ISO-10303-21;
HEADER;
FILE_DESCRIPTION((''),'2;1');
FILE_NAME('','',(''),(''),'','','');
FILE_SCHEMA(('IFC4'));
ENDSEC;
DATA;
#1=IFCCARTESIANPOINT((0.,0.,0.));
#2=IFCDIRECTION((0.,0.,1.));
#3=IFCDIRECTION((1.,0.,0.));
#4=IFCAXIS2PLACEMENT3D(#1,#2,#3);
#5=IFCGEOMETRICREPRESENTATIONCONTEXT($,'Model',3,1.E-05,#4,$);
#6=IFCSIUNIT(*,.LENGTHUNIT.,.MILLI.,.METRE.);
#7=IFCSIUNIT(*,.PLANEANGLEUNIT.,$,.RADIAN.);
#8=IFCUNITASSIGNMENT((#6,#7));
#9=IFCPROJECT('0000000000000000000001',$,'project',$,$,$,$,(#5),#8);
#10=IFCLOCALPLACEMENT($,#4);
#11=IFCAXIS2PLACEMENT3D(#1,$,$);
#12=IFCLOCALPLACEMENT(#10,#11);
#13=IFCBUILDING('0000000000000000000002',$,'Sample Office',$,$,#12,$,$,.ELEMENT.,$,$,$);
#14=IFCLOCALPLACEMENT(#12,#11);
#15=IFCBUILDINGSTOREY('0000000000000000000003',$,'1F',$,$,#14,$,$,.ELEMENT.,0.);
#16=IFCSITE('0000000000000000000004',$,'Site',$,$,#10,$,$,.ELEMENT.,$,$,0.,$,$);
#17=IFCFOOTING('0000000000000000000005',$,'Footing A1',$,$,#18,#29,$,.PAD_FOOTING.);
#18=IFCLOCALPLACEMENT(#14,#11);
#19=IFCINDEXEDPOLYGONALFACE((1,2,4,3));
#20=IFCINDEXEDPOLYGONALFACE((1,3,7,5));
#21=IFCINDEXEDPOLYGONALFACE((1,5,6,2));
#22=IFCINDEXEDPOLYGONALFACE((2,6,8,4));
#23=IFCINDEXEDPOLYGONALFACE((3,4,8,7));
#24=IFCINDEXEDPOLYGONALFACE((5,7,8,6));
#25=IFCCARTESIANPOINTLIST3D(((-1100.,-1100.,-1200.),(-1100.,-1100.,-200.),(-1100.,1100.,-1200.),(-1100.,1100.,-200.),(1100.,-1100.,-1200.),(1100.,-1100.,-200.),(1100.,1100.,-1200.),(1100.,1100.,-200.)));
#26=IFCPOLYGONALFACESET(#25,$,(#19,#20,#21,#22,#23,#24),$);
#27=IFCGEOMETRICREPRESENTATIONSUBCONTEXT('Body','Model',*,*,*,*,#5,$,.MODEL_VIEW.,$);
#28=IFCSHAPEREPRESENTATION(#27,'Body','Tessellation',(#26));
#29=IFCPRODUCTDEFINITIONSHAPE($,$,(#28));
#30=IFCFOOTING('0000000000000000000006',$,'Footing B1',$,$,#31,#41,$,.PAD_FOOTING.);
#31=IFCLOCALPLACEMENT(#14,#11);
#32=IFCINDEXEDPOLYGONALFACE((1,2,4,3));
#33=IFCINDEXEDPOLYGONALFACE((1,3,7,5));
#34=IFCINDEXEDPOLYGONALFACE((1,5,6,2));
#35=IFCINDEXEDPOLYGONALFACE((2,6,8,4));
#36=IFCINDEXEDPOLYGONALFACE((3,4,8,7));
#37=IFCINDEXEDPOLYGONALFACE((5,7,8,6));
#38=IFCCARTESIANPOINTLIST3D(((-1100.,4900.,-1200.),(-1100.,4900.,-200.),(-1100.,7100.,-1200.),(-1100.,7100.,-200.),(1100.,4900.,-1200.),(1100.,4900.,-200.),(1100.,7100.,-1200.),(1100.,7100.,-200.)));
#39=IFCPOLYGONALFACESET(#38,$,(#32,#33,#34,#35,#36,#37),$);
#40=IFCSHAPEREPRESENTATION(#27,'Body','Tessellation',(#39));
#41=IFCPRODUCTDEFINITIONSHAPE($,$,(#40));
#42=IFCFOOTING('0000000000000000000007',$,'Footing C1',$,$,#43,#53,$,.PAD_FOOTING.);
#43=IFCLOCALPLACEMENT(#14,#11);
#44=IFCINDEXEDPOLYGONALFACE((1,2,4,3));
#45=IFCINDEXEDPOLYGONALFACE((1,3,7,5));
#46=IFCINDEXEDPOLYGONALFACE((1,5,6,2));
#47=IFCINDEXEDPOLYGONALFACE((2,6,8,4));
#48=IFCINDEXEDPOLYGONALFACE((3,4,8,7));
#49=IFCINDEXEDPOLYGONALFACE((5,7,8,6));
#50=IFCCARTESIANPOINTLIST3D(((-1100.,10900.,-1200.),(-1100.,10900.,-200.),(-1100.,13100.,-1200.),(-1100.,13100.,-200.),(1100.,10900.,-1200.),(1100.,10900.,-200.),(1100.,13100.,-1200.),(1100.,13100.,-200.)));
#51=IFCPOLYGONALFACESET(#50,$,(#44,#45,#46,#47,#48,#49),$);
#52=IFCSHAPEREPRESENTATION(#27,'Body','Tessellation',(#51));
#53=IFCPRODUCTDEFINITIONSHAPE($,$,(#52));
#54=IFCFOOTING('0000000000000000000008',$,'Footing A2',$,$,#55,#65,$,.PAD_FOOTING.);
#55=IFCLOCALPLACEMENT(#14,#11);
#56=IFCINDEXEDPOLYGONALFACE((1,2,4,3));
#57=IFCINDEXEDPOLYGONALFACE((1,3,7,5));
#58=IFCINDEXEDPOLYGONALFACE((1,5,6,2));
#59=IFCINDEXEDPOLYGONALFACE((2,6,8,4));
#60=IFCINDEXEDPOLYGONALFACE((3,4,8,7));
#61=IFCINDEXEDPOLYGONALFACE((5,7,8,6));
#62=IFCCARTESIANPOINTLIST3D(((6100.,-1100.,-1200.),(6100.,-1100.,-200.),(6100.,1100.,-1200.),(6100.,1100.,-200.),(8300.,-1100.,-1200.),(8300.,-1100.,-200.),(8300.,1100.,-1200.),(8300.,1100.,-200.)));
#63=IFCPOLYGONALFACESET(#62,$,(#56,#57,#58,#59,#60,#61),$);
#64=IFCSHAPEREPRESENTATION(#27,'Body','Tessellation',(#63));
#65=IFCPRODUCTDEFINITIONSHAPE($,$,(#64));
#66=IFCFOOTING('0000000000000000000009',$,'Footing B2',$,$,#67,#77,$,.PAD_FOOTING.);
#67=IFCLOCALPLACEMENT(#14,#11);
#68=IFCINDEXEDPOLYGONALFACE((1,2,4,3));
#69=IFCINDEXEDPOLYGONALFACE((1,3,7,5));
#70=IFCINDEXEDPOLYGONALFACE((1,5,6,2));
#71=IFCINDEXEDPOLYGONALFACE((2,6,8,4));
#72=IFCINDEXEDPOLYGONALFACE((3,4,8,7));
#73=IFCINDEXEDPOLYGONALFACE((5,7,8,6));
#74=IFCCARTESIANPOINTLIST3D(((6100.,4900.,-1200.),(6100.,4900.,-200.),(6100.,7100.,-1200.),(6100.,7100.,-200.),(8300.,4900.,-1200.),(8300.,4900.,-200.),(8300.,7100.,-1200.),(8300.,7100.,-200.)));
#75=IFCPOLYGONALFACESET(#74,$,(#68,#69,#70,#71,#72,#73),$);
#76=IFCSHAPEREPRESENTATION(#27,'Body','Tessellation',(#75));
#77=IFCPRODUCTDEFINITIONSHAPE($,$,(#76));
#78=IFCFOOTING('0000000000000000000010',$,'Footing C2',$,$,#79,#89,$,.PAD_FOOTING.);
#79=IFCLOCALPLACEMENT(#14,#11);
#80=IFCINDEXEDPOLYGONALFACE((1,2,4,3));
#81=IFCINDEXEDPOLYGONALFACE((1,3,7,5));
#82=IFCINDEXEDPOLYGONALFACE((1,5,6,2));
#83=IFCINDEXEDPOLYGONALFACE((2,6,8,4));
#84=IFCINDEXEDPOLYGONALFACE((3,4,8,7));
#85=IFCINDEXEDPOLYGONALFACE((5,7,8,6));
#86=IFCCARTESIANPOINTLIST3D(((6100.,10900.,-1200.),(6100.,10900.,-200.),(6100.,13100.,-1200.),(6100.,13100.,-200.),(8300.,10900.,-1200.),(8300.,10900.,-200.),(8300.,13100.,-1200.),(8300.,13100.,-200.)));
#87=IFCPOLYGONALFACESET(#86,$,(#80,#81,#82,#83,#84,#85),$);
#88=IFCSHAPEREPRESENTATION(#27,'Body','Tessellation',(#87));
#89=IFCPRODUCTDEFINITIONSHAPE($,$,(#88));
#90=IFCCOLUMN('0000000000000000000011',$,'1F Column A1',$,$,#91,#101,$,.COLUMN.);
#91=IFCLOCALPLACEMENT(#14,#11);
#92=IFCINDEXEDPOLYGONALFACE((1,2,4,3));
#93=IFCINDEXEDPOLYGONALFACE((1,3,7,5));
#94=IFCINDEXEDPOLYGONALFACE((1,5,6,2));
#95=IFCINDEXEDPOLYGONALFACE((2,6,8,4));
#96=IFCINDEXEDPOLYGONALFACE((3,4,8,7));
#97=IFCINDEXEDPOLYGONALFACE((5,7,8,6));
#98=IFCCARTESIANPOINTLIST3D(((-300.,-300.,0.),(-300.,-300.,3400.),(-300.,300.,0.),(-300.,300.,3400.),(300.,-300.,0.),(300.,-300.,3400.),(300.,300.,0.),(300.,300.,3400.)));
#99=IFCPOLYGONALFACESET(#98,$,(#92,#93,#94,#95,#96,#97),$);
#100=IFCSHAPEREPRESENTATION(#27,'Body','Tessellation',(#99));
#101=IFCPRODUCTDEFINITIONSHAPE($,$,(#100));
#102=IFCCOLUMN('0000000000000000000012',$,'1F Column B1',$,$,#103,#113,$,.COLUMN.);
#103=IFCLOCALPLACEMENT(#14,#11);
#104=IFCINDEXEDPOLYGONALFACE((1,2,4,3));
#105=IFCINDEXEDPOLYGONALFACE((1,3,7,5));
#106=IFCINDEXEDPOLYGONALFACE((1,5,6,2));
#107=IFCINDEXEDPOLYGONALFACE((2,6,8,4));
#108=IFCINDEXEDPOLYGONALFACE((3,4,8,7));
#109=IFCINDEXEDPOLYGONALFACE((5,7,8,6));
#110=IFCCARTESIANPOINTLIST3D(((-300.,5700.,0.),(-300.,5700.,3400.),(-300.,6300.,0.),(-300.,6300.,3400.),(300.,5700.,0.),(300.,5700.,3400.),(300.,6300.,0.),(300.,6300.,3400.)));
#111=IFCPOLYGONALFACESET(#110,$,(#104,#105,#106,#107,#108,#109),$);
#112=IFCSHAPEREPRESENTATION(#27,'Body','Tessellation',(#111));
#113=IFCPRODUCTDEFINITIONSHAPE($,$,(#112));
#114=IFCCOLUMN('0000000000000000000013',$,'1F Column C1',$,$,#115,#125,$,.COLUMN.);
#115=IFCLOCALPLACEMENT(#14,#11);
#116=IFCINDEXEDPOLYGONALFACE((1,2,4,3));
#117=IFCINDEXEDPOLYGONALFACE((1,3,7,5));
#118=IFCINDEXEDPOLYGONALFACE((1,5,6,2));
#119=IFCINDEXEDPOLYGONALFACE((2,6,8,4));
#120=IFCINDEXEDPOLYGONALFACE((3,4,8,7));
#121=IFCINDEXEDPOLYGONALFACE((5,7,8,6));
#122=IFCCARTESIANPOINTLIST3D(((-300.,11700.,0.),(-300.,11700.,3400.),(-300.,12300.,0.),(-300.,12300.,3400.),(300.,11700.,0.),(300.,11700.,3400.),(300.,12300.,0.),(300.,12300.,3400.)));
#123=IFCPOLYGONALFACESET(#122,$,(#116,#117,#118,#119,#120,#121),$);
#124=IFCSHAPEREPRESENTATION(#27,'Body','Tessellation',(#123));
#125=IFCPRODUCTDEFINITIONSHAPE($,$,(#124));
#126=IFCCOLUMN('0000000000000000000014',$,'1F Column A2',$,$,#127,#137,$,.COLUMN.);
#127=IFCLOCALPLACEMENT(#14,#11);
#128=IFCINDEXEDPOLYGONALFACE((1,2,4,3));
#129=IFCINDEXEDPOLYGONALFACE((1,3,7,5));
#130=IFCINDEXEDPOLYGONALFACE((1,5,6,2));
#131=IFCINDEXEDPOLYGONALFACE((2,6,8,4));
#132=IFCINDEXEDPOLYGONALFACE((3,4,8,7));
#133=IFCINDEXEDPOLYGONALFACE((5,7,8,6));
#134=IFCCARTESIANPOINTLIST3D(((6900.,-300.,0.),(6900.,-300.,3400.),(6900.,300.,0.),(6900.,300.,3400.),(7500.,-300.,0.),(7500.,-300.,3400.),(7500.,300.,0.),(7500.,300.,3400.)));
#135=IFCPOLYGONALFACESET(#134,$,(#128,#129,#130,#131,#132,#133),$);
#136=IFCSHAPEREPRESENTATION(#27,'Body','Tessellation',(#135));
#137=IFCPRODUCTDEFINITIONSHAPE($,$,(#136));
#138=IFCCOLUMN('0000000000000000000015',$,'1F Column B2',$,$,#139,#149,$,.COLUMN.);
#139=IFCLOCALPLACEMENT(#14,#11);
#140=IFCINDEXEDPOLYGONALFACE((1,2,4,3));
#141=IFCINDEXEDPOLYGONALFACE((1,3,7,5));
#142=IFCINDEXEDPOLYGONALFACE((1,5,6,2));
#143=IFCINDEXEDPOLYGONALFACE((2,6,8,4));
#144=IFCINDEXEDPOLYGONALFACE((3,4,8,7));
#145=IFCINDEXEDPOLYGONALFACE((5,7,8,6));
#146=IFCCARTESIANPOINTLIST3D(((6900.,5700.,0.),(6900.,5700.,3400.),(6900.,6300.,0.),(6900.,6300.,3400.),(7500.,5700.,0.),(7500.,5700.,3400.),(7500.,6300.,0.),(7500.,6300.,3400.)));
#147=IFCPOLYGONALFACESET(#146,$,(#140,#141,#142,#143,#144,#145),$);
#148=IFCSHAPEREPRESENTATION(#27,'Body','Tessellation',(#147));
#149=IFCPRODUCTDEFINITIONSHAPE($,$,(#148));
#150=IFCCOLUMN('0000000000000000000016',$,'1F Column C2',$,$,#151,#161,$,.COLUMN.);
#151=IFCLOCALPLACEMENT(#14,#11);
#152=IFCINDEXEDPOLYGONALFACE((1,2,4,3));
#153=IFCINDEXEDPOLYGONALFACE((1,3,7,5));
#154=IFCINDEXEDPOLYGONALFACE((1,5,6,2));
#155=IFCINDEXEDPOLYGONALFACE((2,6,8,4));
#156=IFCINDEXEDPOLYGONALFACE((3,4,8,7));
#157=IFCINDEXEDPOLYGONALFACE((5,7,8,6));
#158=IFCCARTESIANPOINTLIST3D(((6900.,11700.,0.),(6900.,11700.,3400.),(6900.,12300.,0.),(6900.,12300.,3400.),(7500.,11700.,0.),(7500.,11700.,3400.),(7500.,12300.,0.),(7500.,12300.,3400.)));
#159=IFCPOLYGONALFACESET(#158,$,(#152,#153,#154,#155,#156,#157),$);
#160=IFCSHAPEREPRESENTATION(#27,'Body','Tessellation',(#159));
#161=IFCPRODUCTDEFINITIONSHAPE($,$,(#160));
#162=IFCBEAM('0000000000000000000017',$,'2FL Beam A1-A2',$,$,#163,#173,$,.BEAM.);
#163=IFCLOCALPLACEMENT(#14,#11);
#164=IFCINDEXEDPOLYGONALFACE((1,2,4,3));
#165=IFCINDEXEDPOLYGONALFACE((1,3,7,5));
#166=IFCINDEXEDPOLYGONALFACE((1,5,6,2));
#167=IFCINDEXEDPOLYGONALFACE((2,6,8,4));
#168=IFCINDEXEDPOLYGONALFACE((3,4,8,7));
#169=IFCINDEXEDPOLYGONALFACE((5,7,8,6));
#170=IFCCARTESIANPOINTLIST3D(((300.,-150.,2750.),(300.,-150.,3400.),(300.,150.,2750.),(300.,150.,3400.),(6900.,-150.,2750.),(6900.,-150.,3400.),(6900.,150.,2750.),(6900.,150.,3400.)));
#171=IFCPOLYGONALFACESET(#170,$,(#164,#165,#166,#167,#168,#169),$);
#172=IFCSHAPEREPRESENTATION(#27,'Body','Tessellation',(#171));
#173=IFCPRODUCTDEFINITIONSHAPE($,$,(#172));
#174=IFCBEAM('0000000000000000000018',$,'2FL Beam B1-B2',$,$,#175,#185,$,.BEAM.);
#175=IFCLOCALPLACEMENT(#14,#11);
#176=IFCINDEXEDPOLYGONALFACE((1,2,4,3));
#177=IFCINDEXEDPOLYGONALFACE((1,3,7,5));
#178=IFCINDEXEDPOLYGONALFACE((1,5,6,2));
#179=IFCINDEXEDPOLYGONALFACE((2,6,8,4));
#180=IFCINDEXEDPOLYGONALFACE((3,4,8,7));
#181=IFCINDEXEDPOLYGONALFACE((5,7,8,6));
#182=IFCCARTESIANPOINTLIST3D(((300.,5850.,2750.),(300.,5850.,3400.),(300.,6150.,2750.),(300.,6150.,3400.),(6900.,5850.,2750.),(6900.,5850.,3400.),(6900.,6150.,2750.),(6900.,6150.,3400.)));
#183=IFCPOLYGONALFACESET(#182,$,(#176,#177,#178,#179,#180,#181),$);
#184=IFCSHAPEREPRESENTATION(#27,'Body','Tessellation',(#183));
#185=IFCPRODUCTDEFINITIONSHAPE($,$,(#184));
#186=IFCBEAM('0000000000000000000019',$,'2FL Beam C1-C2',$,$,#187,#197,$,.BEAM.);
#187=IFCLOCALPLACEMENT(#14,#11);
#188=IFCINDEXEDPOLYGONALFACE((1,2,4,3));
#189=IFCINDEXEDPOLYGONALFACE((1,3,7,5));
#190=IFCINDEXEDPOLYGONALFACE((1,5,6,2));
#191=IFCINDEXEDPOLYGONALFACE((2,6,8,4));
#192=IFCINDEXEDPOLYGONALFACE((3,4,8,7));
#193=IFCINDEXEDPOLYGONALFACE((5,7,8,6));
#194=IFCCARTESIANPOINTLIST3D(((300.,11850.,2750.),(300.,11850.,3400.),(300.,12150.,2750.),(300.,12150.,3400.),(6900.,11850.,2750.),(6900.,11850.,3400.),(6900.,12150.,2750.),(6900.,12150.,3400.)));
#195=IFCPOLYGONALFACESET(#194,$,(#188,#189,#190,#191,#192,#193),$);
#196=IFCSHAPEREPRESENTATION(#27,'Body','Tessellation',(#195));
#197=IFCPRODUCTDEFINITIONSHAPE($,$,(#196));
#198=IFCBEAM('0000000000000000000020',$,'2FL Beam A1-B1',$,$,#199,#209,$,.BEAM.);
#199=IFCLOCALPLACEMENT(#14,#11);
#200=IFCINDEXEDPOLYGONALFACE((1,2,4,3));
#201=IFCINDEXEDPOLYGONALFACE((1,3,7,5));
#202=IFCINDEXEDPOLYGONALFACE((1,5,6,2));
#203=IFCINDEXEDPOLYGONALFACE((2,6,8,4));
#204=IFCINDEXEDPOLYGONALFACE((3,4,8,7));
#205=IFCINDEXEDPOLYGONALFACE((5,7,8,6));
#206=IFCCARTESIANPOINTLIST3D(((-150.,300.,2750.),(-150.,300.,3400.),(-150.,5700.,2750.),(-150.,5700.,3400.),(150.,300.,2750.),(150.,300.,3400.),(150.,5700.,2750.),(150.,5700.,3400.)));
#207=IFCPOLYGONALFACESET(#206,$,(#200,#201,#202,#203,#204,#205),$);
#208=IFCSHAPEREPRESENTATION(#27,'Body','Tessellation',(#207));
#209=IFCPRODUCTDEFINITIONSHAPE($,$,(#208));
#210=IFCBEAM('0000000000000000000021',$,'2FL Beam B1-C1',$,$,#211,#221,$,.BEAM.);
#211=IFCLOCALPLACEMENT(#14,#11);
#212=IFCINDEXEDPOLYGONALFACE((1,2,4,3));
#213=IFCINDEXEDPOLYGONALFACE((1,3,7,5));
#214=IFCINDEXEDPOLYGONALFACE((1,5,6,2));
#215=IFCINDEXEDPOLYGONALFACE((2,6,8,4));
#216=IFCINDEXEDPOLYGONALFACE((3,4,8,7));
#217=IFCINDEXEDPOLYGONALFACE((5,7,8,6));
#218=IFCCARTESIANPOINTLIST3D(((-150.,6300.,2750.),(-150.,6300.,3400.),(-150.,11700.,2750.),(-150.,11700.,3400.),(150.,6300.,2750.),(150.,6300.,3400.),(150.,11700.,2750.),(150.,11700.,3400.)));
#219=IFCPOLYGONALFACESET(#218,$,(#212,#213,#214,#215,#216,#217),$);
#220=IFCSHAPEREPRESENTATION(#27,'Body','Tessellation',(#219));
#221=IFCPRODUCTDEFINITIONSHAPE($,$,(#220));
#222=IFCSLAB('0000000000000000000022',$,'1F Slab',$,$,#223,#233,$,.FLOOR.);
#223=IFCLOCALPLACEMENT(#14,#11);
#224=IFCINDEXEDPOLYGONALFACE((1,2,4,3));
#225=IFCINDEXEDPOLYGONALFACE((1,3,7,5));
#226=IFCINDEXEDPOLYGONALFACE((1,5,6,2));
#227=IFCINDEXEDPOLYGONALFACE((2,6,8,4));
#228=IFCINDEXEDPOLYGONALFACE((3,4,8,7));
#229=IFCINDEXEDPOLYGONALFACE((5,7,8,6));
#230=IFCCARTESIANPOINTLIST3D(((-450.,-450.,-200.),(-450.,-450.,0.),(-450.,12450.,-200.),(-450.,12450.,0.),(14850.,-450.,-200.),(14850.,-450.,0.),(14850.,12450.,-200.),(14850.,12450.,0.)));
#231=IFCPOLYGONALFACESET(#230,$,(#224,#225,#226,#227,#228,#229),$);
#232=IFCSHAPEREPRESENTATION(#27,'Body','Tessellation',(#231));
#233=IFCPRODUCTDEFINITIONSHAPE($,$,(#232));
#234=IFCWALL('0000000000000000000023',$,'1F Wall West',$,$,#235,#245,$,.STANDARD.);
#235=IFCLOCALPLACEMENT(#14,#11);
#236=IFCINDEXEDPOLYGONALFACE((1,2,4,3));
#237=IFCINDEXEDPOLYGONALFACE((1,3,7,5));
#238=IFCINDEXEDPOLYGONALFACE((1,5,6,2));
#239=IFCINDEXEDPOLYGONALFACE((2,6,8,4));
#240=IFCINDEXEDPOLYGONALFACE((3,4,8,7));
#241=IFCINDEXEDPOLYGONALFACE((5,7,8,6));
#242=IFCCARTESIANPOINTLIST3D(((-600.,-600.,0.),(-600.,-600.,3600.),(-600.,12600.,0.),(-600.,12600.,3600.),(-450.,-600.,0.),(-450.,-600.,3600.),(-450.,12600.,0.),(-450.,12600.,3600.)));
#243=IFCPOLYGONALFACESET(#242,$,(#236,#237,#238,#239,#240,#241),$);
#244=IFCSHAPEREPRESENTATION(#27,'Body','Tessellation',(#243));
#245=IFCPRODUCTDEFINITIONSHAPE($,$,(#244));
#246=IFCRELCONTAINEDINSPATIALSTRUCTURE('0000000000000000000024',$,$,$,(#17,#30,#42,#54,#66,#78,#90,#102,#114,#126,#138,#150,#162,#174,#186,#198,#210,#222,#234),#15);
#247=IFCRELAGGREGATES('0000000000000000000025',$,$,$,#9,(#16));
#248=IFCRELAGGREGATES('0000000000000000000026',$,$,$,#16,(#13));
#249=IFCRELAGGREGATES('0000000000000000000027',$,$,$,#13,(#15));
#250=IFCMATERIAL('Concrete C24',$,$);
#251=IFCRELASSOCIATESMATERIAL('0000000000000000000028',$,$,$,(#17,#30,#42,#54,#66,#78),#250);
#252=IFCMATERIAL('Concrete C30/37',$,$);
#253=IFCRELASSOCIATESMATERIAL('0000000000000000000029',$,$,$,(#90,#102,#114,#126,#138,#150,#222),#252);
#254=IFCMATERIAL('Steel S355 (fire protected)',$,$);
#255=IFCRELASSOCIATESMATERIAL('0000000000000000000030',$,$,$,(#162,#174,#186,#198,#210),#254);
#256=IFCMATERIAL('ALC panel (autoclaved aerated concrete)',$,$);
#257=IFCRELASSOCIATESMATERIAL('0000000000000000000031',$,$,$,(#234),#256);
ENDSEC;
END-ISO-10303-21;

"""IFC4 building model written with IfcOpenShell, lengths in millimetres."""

from ifc_helpers import new_model, si_unit, frame, origin, origin_with_axes, origin_2d, place, context, subcontext, project, spatial, rectangle, extrude, material, element, save


model = new_model("IFC4")

# Units and contexts
model_context = context("Model", 3, precision=1e-05, world=origin_with_axes())
body_context = subcontext(model_context, "Body", "Model", "MODEL_VIEW")
ifc_project = project(units=[si_unit("LENGTHUNIT", "METRE", prefix="MILLI"), si_unit("PLANEANGLEUNIT", "RADIAN")], contexts=[model_context])

# Site, building, storey
site_placement = place(None, origin_with_axes())
site = spatial("IfcSite", under=ifc_project, at=site_placement, Name="Site", CompositionType="ELEMENT", RefElevation=0.0)
building_placement = place(site_placement, origin())
building = spatial("IfcBuilding", under=site, at=building_placement, Name="Sample Office", CompositionType="ELEMENT")
storey_placement = place(building_placement, origin())
storey = spatial("IfcBuildingStorey", under=building, at=storey_placement, Name="1F", CompositionType="ELEMENT", Elevation=0.0)

# Footings
ifc_material_1 = material(Name="Concrete C24")
for number, where, name in (
    (1, (0.0, 0.0, -1200.0), "Footing A1"),
    (2, (0.0, 6000.0, -1200.0), "Footing B1"),
    (3, (0.0, 12000.0, -1200.0), "Footing C1"),
    (4, (7200.0, 0.0, -1200.0), "Footing A2"),
    (5, (7200.0, 6000.0, -1200.0), "Footing B2"),
    (6, (7200.0, 12000.0, -1200.0), "Footing C2"),
):
    element("IfcFooting", number, at=place(storey_placement, frame(where)), inside=storey, material=ifc_material_1, Name=name, PredefinedType="PAD_FOOTING", context=body_context, shape_type="SweptSolid", body=[
        extrude(rectangle(XDim=2200.0, YDim=2200.0, at=origin_2d()), origin(), (0.0, 0.0, 1.0), 1000.0),
    ])

# Columns
ifc_material_2 = material(Name="Concrete C30/37")
for number, where, name in (
    (7, (0.0, 0.0, 0.0), "1F Column A1"),
    (8, (0.0, 6000.0, 0.0), "1F Column B1"),
    (9, (0.0, 12000.0, 0.0), "1F Column C1"),
    (10, (7200.0, 0.0, 0.0), "1F Column A2"),
    (11, (7200.0, 6000.0, 0.0), "1F Column B2"),
    (12, (7200.0, 12000.0, 0.0), "1F Column C2"),
):
    element("IfcColumn", number, at=place(storey_placement, frame(where)), inside=storey, material=ifc_material_2, Name=name, PredefinedType="COLUMN", context=body_context, shape_type="SweptSolid", body=[
        extrude(rectangle(XDim=600.0, YDim=600.0, at=origin_2d()), origin(), (0.0, 0.0, 1.0), 3400.0),
    ])

# Beams
ifc_material_3 = material(Name="Steel S355 (fire protected)")
for number, where, name in (
    (13, (3600.0, 0.0, 2750.0), "2FL Beam A1-A2"),
    (14, (3600.0, 6000.0, 2750.0), "2FL Beam B1-B2"),
    (15, (3600.0, 12000.0, 2750.0), "2FL Beam C1-C2"),
):
    element("IfcBeam", number, at=place(storey_placement, frame(where)), inside=storey, material=ifc_material_3, Name=name, PredefinedType="BEAM", context=body_context, shape_type="SweptSolid", body=[
        extrude(rectangle(XDim=6600.0, YDim=300.0, at=origin_2d()), origin(), (0.0, 0.0, 1.0), 650.0),
    ])
for number, where, name in (
    (16, (0.0, 3000.0, 2750.0), "2FL Beam A1-B1"),
    (17, (0.0, 9000.0, 2750.0), "2FL Beam B1-C1"),
):
    element("IfcBeam", number, at=place(storey_placement, frame(where)), inside=storey, material=ifc_material_3, Name=name, PredefinedType="BEAM", context=body_context, shape_type="SweptSolid", body=[
        extrude(rectangle(XDim=300.0, YDim=5400.0, at=origin_2d()), origin(), (0.0, 0.0, 1.0), 650.0),
    ])

# Slab
slab_placement = place(storey_placement, frame((7200.0, 6000.0, -200.0)))
element("IfcSlab", 18, at=slab_placement, inside=storey, material=ifc_material_2, Name="1F Slab", PredefinedType="FLOOR", context=body_context, shape_type="SweptSolid", body=[
    extrude(rectangle(XDim=15300.0, YDim=12900.0, at=origin_2d()), origin(), (0.0, 0.0, 1.0), 200.0),
])

# Wall
ifc_material_4 = material(Name="ALC panel (autoclaved aerated concrete)")
wall_1_placement = place(storey_placement, frame((-525.0, 6000.0, 0.0)))
element("IfcWall", 19, at=wall_1_placement, inside=storey, material=ifc_material_4, Name="1F Wall West", PredefinedType="STANDARD", context=body_context, shape_type="SweptSolid", body=[
    extrude(rectangle(XDim=150.0, YDim=13200.0, at=origin_2d()), origin(), (0.0, 0.0, 1.0), 3600.0),
])

save(model, "model.ifc")
